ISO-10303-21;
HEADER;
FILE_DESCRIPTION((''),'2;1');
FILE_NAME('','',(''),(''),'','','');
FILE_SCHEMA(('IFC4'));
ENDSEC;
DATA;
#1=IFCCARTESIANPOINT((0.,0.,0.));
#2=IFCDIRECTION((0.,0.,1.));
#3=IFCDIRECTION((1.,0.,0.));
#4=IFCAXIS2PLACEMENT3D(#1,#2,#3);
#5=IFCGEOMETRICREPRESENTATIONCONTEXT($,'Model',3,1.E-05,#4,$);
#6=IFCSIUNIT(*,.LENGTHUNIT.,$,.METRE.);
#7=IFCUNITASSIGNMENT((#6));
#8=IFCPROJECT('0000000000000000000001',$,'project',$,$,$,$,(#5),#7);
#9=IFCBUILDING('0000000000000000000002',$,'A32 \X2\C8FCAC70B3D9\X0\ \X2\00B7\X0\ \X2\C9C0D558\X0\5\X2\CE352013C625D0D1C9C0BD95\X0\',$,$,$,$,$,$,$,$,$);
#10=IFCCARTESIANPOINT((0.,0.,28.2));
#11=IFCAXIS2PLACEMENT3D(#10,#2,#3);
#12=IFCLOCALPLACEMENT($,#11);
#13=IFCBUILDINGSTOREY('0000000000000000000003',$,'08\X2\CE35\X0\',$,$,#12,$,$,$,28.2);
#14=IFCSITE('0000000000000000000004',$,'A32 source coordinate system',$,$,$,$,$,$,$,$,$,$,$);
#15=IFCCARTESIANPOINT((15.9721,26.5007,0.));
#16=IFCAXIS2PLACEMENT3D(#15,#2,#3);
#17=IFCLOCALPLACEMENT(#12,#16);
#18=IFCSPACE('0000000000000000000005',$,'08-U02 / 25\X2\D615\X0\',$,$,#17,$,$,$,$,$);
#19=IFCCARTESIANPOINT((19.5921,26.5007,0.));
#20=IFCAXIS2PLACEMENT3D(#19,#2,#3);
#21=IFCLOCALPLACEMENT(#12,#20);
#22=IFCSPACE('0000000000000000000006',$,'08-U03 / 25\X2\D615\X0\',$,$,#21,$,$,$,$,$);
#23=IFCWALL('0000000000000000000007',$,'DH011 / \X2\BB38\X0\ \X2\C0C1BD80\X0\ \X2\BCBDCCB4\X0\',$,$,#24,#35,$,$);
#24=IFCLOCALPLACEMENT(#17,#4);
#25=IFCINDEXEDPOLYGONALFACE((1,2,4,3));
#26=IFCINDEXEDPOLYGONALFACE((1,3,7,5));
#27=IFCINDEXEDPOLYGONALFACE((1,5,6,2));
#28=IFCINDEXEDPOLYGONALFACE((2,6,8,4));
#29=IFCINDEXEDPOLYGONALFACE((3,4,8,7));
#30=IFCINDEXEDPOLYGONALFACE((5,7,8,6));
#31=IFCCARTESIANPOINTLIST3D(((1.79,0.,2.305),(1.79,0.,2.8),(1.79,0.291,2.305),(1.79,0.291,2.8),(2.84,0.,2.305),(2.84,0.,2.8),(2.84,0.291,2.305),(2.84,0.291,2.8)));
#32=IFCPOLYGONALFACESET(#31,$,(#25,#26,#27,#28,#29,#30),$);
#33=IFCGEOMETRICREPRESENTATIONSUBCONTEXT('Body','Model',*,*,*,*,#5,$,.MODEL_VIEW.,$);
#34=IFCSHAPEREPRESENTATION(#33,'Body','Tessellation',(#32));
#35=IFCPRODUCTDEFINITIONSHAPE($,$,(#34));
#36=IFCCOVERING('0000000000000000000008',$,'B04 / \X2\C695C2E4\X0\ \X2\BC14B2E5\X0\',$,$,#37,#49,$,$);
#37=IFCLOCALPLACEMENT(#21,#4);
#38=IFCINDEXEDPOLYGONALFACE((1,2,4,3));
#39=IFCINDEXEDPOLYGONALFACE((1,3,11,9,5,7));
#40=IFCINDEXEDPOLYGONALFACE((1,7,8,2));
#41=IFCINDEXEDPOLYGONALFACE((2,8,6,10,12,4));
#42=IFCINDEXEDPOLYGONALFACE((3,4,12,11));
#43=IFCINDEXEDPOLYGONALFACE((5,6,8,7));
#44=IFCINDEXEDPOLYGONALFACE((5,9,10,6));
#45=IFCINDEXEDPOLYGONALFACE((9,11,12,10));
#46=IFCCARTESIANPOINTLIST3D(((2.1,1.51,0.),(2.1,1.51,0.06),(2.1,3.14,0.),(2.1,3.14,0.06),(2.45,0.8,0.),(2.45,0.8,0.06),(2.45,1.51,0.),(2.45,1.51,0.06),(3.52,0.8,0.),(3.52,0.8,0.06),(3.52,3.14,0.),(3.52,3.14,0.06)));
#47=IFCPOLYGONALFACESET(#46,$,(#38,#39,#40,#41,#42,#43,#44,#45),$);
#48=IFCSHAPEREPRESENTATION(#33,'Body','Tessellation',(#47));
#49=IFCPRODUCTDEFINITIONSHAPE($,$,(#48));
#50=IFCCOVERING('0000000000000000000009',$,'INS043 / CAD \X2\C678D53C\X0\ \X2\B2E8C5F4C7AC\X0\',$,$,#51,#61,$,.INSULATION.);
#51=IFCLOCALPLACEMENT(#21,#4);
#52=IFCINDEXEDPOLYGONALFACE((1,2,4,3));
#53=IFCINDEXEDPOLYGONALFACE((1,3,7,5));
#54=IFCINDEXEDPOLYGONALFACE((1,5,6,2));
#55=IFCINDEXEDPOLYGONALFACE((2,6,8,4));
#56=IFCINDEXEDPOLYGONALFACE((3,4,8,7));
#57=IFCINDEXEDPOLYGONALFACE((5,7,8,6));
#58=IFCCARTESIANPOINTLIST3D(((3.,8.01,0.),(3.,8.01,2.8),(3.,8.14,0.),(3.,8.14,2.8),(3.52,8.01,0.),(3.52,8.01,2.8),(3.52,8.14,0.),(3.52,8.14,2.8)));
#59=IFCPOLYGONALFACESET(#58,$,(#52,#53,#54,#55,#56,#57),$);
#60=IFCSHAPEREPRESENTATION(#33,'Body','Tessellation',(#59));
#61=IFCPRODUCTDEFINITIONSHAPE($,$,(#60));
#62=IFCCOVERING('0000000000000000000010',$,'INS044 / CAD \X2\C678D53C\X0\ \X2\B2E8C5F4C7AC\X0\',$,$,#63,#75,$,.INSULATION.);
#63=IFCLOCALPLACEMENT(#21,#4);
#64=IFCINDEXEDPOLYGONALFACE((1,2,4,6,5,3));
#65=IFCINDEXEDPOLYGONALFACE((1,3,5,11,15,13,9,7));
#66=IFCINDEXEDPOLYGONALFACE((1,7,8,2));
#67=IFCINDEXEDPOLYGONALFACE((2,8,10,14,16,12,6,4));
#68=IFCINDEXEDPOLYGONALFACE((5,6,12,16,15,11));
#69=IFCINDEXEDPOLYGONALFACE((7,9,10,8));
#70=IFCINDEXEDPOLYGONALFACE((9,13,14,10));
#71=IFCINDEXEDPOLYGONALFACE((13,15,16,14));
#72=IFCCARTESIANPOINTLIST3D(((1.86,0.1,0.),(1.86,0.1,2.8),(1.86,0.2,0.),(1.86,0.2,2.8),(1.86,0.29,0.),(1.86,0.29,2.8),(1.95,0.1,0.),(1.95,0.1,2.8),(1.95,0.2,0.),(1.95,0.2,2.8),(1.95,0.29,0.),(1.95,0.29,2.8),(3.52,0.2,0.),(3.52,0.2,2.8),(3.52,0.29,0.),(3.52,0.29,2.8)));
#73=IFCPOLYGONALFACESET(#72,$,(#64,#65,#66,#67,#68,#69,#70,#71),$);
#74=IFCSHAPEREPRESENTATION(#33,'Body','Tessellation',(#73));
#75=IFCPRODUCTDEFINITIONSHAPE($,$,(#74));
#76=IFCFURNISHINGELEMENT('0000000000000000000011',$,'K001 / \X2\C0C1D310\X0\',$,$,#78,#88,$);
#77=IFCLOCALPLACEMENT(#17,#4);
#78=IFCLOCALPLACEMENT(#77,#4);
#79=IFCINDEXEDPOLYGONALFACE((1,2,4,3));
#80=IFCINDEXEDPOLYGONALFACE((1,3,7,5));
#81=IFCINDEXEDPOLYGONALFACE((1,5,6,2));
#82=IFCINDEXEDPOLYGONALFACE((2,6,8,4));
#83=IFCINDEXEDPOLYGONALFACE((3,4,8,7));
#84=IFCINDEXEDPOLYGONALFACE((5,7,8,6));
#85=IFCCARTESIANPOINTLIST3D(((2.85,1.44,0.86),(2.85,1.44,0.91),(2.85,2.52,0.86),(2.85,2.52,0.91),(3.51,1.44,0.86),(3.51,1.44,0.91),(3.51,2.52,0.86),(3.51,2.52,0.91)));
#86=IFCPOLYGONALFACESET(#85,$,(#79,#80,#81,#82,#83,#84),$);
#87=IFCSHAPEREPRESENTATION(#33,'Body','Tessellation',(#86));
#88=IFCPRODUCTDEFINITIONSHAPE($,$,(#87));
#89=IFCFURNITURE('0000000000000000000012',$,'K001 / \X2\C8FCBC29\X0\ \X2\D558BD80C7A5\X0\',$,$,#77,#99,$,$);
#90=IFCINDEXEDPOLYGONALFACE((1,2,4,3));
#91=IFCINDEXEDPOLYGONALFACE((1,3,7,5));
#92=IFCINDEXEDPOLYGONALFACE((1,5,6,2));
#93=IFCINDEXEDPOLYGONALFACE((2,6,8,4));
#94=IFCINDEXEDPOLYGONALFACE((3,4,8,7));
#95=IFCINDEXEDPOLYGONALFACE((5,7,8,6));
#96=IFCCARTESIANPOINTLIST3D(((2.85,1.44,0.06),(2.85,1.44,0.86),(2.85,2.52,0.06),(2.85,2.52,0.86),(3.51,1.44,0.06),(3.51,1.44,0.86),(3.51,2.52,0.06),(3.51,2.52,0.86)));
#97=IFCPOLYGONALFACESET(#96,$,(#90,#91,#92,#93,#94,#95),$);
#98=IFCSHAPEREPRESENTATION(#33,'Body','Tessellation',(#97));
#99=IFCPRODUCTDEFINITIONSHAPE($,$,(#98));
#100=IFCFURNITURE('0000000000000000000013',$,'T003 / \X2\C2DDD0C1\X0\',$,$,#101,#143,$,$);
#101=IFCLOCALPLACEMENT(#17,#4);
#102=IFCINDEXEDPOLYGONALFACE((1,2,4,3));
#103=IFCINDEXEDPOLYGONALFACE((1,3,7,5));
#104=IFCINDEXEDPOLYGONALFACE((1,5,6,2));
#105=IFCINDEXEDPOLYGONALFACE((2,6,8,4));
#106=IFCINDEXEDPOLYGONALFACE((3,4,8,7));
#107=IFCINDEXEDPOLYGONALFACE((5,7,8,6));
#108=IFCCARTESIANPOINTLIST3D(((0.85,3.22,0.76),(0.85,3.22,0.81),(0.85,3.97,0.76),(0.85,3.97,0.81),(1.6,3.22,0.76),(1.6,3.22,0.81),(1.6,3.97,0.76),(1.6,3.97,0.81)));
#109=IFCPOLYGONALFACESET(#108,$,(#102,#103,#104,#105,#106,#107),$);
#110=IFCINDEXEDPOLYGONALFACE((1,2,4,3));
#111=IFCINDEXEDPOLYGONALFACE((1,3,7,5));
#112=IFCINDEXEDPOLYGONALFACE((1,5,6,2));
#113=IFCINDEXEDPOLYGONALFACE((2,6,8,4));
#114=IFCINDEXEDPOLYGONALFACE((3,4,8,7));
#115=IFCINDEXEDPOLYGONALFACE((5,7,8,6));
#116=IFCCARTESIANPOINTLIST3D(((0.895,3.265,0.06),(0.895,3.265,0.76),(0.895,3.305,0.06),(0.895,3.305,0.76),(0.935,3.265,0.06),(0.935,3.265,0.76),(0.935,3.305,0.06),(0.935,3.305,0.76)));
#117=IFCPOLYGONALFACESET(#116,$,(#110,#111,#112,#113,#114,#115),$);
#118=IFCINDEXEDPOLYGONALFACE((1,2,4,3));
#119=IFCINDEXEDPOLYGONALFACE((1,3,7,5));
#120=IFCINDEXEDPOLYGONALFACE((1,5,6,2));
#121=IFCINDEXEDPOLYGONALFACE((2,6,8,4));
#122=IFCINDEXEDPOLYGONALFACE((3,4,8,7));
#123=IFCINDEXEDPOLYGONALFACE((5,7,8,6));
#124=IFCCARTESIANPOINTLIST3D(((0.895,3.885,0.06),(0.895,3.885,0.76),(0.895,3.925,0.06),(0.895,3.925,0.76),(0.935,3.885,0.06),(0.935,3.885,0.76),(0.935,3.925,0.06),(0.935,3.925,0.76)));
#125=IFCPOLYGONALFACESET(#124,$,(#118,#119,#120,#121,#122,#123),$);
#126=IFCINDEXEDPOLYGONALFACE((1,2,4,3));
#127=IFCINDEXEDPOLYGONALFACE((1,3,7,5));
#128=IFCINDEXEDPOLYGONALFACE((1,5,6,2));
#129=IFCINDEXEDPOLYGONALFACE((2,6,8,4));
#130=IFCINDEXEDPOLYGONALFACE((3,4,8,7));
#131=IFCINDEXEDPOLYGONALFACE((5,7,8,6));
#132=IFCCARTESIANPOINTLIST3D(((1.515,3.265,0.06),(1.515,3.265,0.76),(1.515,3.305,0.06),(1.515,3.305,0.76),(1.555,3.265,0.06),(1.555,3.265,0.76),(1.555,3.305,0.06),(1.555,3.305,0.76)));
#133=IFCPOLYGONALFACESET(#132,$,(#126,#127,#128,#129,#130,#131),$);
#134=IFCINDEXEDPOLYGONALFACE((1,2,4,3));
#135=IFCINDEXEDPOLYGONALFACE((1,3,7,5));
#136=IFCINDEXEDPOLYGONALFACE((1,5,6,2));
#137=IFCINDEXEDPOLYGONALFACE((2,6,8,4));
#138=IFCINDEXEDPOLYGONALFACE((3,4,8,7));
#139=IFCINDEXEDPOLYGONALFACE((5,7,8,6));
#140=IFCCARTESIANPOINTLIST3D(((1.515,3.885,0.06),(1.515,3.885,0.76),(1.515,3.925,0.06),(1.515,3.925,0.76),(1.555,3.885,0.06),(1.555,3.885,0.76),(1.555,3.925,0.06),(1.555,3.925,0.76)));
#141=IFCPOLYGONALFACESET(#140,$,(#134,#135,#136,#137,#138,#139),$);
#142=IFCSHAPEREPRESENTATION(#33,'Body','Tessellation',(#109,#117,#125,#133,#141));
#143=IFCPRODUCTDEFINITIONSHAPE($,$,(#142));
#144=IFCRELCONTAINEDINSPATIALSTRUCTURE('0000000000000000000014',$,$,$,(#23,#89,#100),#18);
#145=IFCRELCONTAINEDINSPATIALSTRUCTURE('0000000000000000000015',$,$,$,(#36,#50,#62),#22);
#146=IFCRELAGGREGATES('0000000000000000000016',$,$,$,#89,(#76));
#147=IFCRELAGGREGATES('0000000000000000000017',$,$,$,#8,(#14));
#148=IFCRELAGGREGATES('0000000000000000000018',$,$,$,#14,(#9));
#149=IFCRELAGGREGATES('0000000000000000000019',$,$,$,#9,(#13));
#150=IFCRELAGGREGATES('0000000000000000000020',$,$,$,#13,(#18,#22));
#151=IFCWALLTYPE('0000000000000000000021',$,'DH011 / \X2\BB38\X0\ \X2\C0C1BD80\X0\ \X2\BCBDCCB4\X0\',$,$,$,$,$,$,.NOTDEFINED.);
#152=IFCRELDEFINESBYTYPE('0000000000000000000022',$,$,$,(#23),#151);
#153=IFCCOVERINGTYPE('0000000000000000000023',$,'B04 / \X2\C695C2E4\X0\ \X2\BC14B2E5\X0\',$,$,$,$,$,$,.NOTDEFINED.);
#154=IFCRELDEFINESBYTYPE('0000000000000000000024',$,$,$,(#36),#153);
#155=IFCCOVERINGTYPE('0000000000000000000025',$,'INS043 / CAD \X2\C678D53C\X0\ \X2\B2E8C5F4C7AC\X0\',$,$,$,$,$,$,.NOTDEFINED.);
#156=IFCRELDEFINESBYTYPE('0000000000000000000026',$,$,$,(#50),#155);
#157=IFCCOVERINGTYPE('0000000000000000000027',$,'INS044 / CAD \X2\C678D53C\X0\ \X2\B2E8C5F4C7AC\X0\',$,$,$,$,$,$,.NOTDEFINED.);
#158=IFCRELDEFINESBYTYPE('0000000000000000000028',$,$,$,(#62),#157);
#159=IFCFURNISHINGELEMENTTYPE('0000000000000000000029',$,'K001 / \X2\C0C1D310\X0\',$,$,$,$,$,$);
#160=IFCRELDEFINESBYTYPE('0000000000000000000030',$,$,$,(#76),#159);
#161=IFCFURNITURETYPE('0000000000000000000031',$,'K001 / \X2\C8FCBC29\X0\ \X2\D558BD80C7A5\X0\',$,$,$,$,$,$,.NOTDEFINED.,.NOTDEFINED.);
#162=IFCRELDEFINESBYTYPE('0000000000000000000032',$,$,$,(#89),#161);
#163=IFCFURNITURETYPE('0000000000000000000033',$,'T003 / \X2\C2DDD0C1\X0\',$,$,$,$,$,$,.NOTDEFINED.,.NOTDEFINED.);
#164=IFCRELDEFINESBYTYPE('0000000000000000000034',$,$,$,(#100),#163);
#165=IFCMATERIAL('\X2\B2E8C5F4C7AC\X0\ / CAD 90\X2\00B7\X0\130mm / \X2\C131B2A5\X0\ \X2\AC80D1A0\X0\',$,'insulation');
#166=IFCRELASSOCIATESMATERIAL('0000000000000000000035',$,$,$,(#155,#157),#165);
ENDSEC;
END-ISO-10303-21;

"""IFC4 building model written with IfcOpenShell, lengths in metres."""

from ifc_helpers import new_model, si_unit, frame, origin, origin_with_axes, place, context, subcontext, project, spatial, polyline, outline, extrude, source, transform, mapped, material, type_object, type_shapes, element, aggregate, save


model = new_model("IFC4")

# Units and contexts
model_context = context("Model", 3, precision=1e-05, world=origin_with_axes())
body_context = subcontext(model_context, "Body", "Model", "MODEL_VIEW")
ifc_project = project(units=[si_unit("LENGTHUNIT", "METRE")], contexts=[model_context])

# Site, building, storey, space
site = spatial("IfcSite", under=ifc_project, Name="A32 source coordinate system")
building = spatial("IfcBuilding", under=site, Name="A32 주거동 · 지하5층–옥탑지붕")
storey_placement = place(None, frame((0.0, 0.0, 28.2), z_axis=(0.0, 0.0, 1.0), x_axis=(1.0, 0.0, 0.0)))
storey = spatial("IfcBuildingStorey", under=building, at=storey_placement, Name="08층", Elevation=28.2)
space_1_placement = place(storey_placement, frame((15.9721, 26.5007, 0.0), z_axis=(0.0, 0.0, 1.0), x_axis=(1.0, 0.0, 0.0)))
space_1 = spatial("IfcSpace", under=storey, at=space_1_placement, Name="08-U02 / 25형")

# Wall
wall_type_1 = type_object("IfcWallType", Name="DH011 / 문 상부 벽체", PredefinedType="NOTDEFINED")
shared_shape_1 = source(origin(), body_context, "Body", "SweptSolid", [
    extrude(outline(polyline([(2.84, 0.0), (1.79, 0.0), (1.79, 0.291), (2.84, 0.291), (2.84, 0.0)])), frame((0.0, 0.0, 2.305)), (0.0, 0.0, 1.0), 0.495),
])
type_shapes(wall_type_1, [shared_shape_1])
wall_1_placement = place(space_1_placement, origin_with_axes())
element("IfcWall", 1, at=wall_1_placement, inside=space_1, type_object=wall_type_1, Name="DH011 / 문 상부 벽체", context=body_context, shape_type="MappedRepresentation", body=[
    mapped(shared_shape_1, transform((0.0, 0.0, 0.0), scale=1.0)),
])

# Shared definitions
space_2_placement = place(storey_placement, frame((19.5921, 26.5007, 0.0), z_axis=(0.0, 0.0, 1.0), x_axis=(1.0, 0.0, 0.0)))
space_2 = spatial("IfcSpace", under=storey, at=space_2_placement, Name="08-U03 / 25형")

# Coverings
covering_type_1 = type_object("IfcCoveringType", Name="B04 / 욕실 바닥", PredefinedType="NOTDEFINED")
shared_shape_2 = source(origin(), body_context, "Body", "SweptSolid", [
    extrude(outline(polyline([(2.1, 1.51), (2.1, 3.14), (3.52, 3.14), (3.52, 0.8), (2.45, 0.8), (2.45, 1.51), (2.1, 1.51)])), origin(), (0.0, 0.0, 1.0), 0.06),
])
type_shapes(covering_type_1, [shared_shape_2])
covering_1_placement = place(space_2_placement, origin_with_axes())
element("IfcCovering", 2, at=covering_1_placement, inside=space_2, type_object=covering_type_1, Name="B04 / 욕실 바닥", context=body_context, shape_type="MappedRepresentation", body=[
    mapped(shared_shape_2, transform((0.0, 0.0, 0.0), scale=1.0)),
])
ifc_material = material(Name="단열재 / CAD 90·130mm / 성능 검토", Category="insulation")
covering_type_2 = type_object("IfcCoveringType", Name="INS043 / CAD 외피 단열재", PredefinedType="NOTDEFINED", material=ifc_material)
shared_shape_3 = source(origin(), body_context, "Body", "SweptSolid", [
    extrude(outline(polyline([(3.52, 8.14), (3.52, 8.01), (3.0, 8.01), (3.0, 8.14), (3.52, 8.14)])), origin(), (0.0, 0.0, 1.0), 2.8),
])
type_shapes(covering_type_2, [shared_shape_3])
covering_2_placement = place(space_2_placement, origin_with_axes())
element("IfcCovering", 3, at=covering_2_placement, inside=space_2, type_object=covering_type_2, Name="INS043 / CAD 외피 단열재", PredefinedType="INSULATION", context=body_context, shape_type="MappedRepresentation", body=[
    mapped(shared_shape_3, transform((0.0, 0.0, 0.0), scale=1.0)),
])
covering_type_3 = type_object("IfcCoveringType", Name="INS044 / CAD 외피 단열재", PredefinedType="NOTDEFINED", material=ifc_material)
shared_shape_4 = source(origin(), body_context, "Body", "SweptSolid", [
    extrude(outline(polyline([(1.86, 0.2), (1.86, 0.29), (1.95, 0.29), (3.52, 0.29), (3.52, 0.2), (1.95, 0.2), (1.95, 0.1), (1.86, 0.1), (1.86, 0.2)])), origin(), (0.0, 0.0, 1.0), 2.8),
])
type_shapes(covering_type_3, [shared_shape_4])
covering_3_placement = place(space_2_placement, origin_with_axes())
element("IfcCovering", 4, at=covering_3_placement, inside=space_2, type_object=covering_type_3, Name="INS044 / CAD 외피 단열재", PredefinedType="INSULATION", context=body_context, shape_type="MappedRepresentation", body=[
    mapped(shared_shape_4, transform((0.0, 0.0, 0.0), scale=1.0)),
])

# Furnishing element
furnishing_element_type_1 = type_object("IfcFurnishingElementType", Name="K001 / 상판")
shared_shape_5 = source(origin(), body_context, "Body", "SweptSolid", [
    extrude(outline(polyline([(2.85, 2.52), (3.51, 2.52), (3.51, 1.44), (2.85, 1.44), (2.85, 2.52)])), frame((0.0, 0.0, 0.86)), (0.0, 0.0, 1.0), 0.05),
])
type_shapes(furnishing_element_type_1, [shared_shape_5])
furniture_1_placement = place(space_1_placement, origin_with_axes())
furnishing_1_placement = place(furniture_1_placement, origin_with_axes())
furnishing_1 = element("IfcFurnishingElement", 5, at=furnishing_1_placement, type_object=furnishing_element_type_1, Name="K001 / 상판", context=body_context, shape_type="MappedRepresentation", body=[
    mapped(shared_shape_5, transform((0.0, 0.0, 0.0), scale=1.0)),
])

# Furniture
furniture_type_1 = type_object("IfcFurnitureType", Name="K001 / 주방 하부장", AssemblyPlace="NOTDEFINED", PredefinedType="NOTDEFINED")
shared_shape_6 = source(origin(), body_context, "Body", "SweptSolid", [
    extrude(outline(polyline([(2.85, 1.44), (2.85, 2.52), (3.51, 2.52), (3.51, 1.44), (2.85, 1.44)])), frame((0.0, 0.0, 0.06)), (0.0, 0.0, 1.0), 0.8),
])
type_shapes(furniture_type_1, [shared_shape_6])
furniture_1 = element("IfcFurniture", 6, at=furniture_1_placement, inside=space_1, type_object=furniture_type_1, Name="K001 / 주방 하부장", context=body_context, shape_type="MappedRepresentation", body=[
    mapped(shared_shape_6, transform((0.0, 0.0, 0.0), scale=1.0)),
])
aggregate(furniture_1, [furnishing_1])
furniture_type_2 = type_object("IfcFurnitureType", Name="T003 / 식탁", AssemblyPlace="NOTDEFINED", PredefinedType="NOTDEFINED")
shared_shape_7 = source(origin(), body_context, "Body", "SweptSolid", [
    extrude(outline(polyline([(1.6, 3.97), (1.6, 3.22), (0.85, 3.22), (0.85, 3.97), (1.6, 3.97)])), frame((0.0, 0.0, 0.76)), (0.0, 0.0, 1.0), 0.05),
    extrude(outline(polyline([(0.895, 3.265), (0.895, 3.305), (0.935, 3.305), (0.935, 3.265), (0.895, 3.265)])), frame((0.0, 0.0, 0.06)), (0.0, 0.0, 1.0), 0.7),
    extrude(outline(polyline([(0.895, 3.885), (0.895, 3.925), (0.935, 3.925), (0.935, 3.885), (0.895, 3.885)])), frame((0.0, 0.0, 0.06)), (0.0, 0.0, 1.0), 0.7),
    extrude(outline(polyline([(1.515, 3.265), (1.515, 3.305), (1.555, 3.305), (1.555, 3.265), (1.515, 3.265)])), frame((0.0, 0.0, 0.06)), (0.0, 0.0, 1.0), 0.7),
    extrude(outline(polyline([(1.515, 3.885), (1.515, 3.925), (1.555, 3.925), (1.555, 3.885), (1.515, 3.885)])), frame((0.0, 0.0, 0.06)), (0.0, 0.0, 1.0), 0.7),
])
type_shapes(furniture_type_2, [shared_shape_7])
furniture_2_placement = place(space_1_placement, origin_with_axes())
element("IfcFurniture", 7, at=furniture_2_placement, inside=space_1, type_object=furniture_type_2, Name="T003 / 식탁", context=body_context, shape_type="MappedRepresentation", body=[
    mapped(shared_shape_7, transform((0.0, 0.0, 0.0), scale=1.0)),
])

save(model, "model.ifc")
